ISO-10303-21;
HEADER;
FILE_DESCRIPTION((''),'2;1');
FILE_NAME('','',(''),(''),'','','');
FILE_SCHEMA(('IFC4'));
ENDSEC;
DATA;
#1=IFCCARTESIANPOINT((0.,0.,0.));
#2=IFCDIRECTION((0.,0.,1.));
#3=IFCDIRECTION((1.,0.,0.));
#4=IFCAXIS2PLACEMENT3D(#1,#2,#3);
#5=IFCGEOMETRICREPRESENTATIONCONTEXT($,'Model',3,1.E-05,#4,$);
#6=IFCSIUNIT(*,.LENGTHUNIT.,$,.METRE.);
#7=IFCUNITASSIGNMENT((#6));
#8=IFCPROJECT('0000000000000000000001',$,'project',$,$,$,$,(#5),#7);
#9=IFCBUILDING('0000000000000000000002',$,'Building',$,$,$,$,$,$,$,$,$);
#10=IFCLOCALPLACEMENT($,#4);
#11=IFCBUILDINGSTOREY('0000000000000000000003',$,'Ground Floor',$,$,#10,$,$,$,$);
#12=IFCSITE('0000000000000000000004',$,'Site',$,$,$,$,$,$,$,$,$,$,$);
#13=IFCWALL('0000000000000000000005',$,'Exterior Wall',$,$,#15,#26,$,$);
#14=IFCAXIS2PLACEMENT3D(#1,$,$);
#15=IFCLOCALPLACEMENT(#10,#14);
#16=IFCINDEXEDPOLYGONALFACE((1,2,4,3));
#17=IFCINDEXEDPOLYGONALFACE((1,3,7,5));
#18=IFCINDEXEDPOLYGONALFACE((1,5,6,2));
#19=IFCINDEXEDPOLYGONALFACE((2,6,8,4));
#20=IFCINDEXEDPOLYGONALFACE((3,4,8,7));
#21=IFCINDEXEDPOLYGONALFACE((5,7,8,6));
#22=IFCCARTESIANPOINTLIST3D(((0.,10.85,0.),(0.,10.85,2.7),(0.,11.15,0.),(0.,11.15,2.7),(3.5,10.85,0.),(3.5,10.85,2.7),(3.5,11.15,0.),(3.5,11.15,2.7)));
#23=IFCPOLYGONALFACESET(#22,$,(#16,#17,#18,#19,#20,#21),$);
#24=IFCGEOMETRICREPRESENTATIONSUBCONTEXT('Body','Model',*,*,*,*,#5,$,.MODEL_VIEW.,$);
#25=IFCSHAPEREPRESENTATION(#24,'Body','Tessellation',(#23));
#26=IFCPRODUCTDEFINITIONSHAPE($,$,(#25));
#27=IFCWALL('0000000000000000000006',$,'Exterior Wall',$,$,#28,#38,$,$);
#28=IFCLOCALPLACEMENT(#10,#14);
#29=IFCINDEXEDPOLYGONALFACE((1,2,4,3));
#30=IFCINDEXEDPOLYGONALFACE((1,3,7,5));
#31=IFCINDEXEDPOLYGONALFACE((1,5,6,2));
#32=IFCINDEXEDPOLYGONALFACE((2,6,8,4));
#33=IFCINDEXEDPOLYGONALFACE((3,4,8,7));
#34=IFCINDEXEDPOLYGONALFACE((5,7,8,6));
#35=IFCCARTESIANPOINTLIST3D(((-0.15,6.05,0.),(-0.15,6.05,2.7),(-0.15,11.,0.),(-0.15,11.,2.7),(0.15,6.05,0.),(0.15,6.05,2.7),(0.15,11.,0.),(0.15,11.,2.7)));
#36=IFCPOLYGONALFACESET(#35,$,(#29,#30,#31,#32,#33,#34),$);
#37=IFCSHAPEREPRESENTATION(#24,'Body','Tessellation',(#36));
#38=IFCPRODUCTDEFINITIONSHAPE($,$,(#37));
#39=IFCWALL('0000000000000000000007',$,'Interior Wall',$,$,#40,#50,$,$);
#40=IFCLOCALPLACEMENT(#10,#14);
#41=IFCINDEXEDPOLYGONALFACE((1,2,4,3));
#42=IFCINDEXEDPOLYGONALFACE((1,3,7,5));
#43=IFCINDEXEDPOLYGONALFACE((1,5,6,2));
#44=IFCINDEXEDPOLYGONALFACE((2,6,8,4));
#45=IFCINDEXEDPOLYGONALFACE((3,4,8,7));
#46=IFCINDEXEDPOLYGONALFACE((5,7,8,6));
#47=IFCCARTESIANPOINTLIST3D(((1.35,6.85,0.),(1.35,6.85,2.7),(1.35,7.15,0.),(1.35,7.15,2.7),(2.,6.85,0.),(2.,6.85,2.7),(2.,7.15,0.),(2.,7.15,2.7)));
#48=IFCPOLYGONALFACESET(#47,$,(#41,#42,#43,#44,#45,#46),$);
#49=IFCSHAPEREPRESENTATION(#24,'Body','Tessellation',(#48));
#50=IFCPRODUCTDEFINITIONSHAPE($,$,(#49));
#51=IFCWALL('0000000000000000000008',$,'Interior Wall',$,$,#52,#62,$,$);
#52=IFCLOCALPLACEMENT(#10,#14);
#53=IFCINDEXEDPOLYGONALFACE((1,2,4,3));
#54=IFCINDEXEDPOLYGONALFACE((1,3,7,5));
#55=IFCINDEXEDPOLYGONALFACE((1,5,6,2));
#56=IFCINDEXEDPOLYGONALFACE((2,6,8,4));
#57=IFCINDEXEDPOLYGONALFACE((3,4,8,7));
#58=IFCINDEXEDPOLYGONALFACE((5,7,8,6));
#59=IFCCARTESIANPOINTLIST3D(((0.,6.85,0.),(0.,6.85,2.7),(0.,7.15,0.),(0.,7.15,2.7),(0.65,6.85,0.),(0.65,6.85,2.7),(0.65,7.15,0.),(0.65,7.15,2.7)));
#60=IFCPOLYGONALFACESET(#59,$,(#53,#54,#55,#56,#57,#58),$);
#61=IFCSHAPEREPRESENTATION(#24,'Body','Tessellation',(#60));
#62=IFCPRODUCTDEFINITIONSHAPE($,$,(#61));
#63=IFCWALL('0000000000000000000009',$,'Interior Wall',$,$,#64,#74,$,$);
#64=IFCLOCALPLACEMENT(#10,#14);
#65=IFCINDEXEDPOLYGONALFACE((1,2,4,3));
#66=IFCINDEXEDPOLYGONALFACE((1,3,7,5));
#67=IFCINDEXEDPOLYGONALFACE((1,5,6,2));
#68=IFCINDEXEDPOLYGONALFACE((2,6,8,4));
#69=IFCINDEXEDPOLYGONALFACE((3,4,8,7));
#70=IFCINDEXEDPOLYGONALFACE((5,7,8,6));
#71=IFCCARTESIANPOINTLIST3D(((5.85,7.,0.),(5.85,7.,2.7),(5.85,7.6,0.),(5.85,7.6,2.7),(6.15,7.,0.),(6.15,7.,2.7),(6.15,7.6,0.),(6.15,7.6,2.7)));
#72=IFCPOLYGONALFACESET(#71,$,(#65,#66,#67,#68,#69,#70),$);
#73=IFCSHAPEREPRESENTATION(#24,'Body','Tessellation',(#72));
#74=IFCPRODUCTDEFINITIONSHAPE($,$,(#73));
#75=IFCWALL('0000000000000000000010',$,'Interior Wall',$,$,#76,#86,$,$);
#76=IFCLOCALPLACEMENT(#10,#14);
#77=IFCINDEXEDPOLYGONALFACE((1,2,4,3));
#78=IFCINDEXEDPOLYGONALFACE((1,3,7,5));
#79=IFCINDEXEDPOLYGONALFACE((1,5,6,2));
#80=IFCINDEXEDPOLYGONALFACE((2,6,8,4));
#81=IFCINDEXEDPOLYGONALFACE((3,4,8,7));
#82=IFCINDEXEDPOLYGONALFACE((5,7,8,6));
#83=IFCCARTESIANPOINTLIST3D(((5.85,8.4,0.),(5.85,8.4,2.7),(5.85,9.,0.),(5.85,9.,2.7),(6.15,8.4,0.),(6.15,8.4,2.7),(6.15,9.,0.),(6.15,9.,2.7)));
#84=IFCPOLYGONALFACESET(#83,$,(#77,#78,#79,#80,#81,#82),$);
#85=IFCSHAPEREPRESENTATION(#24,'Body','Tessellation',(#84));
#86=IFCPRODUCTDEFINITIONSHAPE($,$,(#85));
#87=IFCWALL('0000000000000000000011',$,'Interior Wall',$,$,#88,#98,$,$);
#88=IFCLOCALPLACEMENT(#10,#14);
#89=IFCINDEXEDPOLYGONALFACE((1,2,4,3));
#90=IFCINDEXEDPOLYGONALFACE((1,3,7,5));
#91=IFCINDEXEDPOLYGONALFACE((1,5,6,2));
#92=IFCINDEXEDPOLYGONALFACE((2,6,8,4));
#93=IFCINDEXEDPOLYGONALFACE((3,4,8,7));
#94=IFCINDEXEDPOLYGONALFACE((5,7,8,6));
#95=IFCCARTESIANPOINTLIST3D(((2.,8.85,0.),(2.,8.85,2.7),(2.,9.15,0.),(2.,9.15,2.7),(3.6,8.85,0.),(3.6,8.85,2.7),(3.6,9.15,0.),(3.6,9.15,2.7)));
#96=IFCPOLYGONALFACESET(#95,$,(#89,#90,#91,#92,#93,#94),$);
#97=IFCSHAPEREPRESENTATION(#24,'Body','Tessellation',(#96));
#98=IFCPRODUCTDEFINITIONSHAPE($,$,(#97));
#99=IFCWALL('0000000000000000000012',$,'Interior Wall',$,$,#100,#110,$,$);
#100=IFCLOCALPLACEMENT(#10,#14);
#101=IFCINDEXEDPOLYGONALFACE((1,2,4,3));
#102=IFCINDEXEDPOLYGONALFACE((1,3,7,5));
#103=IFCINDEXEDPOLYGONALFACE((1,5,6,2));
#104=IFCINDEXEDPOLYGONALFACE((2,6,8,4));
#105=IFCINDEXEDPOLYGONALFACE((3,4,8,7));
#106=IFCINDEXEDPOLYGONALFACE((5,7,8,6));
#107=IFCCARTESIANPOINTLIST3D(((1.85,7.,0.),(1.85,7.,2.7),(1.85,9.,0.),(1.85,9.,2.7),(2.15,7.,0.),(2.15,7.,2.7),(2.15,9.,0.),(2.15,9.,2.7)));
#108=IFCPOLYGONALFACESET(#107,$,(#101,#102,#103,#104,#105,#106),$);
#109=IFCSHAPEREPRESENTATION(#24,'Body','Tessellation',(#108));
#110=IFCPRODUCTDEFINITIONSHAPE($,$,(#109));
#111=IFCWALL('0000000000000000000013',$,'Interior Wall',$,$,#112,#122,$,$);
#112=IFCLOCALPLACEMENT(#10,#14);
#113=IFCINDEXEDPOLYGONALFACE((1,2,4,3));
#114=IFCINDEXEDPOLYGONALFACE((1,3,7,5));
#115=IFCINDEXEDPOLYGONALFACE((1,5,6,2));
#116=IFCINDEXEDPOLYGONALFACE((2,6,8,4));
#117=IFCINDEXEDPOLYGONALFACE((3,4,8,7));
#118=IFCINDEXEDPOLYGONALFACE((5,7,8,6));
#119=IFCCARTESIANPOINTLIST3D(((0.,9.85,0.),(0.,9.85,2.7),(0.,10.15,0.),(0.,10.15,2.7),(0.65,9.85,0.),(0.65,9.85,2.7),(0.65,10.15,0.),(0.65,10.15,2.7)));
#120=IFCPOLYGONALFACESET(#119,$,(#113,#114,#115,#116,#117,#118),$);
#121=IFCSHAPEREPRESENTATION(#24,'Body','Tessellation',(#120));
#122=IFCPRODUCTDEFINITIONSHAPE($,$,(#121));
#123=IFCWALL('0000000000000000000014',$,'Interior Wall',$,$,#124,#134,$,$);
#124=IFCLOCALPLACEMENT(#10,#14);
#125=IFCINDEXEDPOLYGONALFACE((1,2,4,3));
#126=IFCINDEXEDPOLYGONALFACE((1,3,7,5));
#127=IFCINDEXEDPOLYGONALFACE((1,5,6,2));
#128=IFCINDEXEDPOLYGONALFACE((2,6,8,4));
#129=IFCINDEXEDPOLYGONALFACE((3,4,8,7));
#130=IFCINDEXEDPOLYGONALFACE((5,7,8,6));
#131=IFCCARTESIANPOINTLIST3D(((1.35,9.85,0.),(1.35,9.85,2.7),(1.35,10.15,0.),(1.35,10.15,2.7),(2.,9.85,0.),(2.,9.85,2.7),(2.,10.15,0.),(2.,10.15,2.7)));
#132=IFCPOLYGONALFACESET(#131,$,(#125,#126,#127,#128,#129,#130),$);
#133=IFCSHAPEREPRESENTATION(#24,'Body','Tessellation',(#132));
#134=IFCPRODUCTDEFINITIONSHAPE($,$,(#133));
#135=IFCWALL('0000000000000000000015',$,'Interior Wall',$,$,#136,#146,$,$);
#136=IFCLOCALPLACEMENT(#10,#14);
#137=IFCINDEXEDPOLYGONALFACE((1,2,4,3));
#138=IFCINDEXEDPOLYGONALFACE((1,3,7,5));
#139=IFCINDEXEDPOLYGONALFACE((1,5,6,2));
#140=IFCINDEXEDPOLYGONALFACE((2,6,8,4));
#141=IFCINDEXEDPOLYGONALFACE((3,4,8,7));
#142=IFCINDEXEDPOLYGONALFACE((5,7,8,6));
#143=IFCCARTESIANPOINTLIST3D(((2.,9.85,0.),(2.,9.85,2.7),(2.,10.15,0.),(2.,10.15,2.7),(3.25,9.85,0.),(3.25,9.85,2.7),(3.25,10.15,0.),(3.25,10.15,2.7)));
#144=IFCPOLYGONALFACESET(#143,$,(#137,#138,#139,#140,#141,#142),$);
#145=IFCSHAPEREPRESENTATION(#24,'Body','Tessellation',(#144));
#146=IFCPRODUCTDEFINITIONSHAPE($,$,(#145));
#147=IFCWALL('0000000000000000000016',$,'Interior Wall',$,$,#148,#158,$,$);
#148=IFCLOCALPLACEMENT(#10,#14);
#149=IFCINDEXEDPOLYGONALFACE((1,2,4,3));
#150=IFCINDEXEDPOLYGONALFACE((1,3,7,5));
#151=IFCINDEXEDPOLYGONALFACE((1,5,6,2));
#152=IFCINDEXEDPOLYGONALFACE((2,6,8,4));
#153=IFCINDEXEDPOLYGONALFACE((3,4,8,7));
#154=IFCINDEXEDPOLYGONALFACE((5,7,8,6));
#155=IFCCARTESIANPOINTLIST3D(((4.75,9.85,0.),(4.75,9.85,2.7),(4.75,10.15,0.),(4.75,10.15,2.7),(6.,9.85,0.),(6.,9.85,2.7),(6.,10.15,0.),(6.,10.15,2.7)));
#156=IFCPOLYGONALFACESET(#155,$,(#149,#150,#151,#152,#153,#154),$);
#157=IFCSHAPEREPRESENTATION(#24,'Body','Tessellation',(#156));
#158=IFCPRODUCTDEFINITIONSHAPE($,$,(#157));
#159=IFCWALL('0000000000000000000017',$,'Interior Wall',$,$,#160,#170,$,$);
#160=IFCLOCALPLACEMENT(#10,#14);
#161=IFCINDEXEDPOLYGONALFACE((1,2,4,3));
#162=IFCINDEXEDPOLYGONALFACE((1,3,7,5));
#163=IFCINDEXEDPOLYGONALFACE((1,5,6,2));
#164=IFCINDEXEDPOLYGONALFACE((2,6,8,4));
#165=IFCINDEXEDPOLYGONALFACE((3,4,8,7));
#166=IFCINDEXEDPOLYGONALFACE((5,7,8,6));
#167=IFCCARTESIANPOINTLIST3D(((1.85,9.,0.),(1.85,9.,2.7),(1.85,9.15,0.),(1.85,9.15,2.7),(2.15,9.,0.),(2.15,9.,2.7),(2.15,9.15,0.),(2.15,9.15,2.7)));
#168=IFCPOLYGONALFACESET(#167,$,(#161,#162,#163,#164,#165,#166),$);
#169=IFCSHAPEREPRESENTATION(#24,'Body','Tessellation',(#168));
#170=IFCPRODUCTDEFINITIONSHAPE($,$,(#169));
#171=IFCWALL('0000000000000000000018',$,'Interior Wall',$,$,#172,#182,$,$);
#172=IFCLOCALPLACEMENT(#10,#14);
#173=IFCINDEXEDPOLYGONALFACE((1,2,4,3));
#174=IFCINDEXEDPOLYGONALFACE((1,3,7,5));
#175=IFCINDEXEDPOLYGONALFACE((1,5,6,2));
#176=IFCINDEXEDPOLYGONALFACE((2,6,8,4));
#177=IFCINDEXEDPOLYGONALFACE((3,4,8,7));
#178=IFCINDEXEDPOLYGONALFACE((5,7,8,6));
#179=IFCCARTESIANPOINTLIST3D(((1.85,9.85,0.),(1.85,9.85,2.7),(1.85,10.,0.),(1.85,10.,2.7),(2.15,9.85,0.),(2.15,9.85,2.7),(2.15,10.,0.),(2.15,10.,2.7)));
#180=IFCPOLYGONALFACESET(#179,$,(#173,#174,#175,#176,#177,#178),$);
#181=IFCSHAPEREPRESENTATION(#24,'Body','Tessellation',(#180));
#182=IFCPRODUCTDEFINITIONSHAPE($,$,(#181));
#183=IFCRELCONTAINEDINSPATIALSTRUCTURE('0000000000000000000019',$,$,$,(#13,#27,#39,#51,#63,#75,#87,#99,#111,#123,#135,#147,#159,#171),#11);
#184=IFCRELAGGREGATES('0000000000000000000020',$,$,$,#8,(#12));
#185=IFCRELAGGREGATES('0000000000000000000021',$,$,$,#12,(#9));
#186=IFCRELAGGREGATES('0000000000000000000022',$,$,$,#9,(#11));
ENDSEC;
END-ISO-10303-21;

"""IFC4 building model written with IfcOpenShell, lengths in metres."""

from ifc_helpers import new_model, si_unit, frame, origin_with_axes, place, context, subcontext, project, spatial, indexed_curve, outline, extrude, element, save


model = new_model("IFC4")

# Units and contexts
model_context = context("Model", 3, precision=1e-05, world=origin_with_axes())
body_context = subcontext(model_context, "Body", "Model", "MODEL_VIEW")
ifc_project = project(units=[si_unit("LENGTHUNIT", "METRE")], contexts=[model_context])

# Site, building, storey
site = spatial("IfcSite", under=ifc_project, Name="Site")
building = spatial("IfcBuilding", under=site, Name="Building")
storey_placement = place(None, origin_with_axes())
storey = spatial("IfcBuildingStorey", under=building, at=storey_placement, Name="Ground Floor")

# Walls
wall_1_placement = place(storey_placement, frame((3.5, 11.0, 0.0), z_axis=(0.0, 0.0, 1.0), x_axis=(-1.0, 0.0, 0.0)))
element("IfcWall", 1, at=wall_1_placement, inside=storey, Name="Exterior Wall", context=body_context, shape_type="SweptSolid", body=[
    extrude(outline(indexed_curve([(0.0, 0.0), (0.0, 0.3), (3.5, 0.3), (3.5, 0.0), (0.0, 0.0)], self_intersect=False)), frame((0.0, -0.15, 0.0), z_axis=(0.0, 0.0, 1.0), x_axis=(1.0, 0.0, 0.0)), (0.0, 0.0, 1.0), 2.7),
])
wall_2_placement = place(storey_placement, frame((0.0, 11.0, 0.0), z_axis=(0.0, 0.0, 1.0), x_axis=(0.0, -1.0, 0.0)))
element("IfcWall", 2, at=wall_2_placement, inside=storey, Name="Exterior Wall", context=body_context, shape_type="SweptSolid", body=[
    extrude(outline(indexed_curve([(0.0, 0.0), (0.0, 0.3), (4.95, 0.3), (4.95, 0.0), (0.0, 0.0)], self_intersect=False)), frame((0.0, -0.15, 0.0), z_axis=(0.0, 0.0, 1.0), x_axis=(1.0, 0.0, 0.0)), (0.0, 0.0, 1.0), 2.7),
])
for number, where, z_axis, x_axis, name in (
    (3, (2.0, 7.0, 0.0), (0.0, 0.0, 1.0), (-1.0, 0.0, 0.0), "Interior Wall"),
    (4, (0.65, 7.0, 0.0), (0.0, 0.0, 1.0), (-1.0, 0.0, 0.0), "Interior Wall"),
):
    element("IfcWall", number, at=place(storey_placement, frame(where, z_axis=z_axis, x_axis=x_axis)), inside=storey, Name=name, context=body_context, shape_type="SweptSolid", body=[
        extrude(outline(indexed_curve([(0.0, 0.0), (0.0, 0.3), (0.65, 0.3), (0.65, 0.0), (0.0, 0.0)], self_intersect=False)), frame((0.0, -0.15, 0.0), z_axis=(0.0, 0.0, 1.0), x_axis=(1.0, 0.0, 0.0)), (0.0, 0.0, 1.0), 2.7),
    ])
for number, where, z_axis, x_axis, name in (
    (5, (6.0, 7.0, 0.0), (0.0, 0.0, 1.0), (0.0, 1.0, 0.0), "Interior Wall"),
    (6, (6.0, 8.4, 0.0), (0.0, 0.0, 1.0), (0.0, 1.0, 0.0), "Interior Wall"),
):
    element("IfcWall", number, at=place(storey_placement, frame(where, z_axis=z_axis, x_axis=x_axis)), inside=storey, Name=name, context=body_context, shape_type="SweptSolid", body=[
        extrude(outline(indexed_curve([(0.0, 0.0), (0.0, 0.3), (0.6, 0.3), (0.6, 0.0), (0.0, 0.0)], self_intersect=False)), frame((0.0, -0.15, 0.0), z_axis=(0.0, 0.0, 1.0), x_axis=(1.0, 0.0, 0.0)), (0.0, 0.0, 1.0), 2.7),
    ])
wall_3_placement = place(storey_placement, frame((3.6, 9.0, 0.0), z_axis=(0.0, 0.0, 1.0), x_axis=(-1.0, 0.0, 0.0)))
element("IfcWall", 7, at=wall_3_placement, inside=storey, Name="Interior Wall", context=body_context, shape_type="SweptSolid", body=[
    extrude(outline(indexed_curve([(0.0, 0.0), (0.0, 0.3), (1.6, 0.3), (1.6, 0.0), (0.0, 0.0)], self_intersect=False)), frame((0.0, -0.15, 0.0), z_axis=(0.0, 0.0, 1.0), x_axis=(1.0, 0.0, 0.0)), (0.0, 0.0, 1.0), 2.7),
])
wall_4_placement = place(storey_placement, frame((2.0, 9.0, 0.0), z_axis=(0.0, 0.0, 1.0), x_axis=(0.0, -1.0, 0.0)))
element("IfcWall", 8, at=wall_4_placement, inside=storey, Name="Interior Wall", context=body_context, shape_type="SweptSolid", body=[
    extrude(outline(indexed_curve([(0.0, 0.0), (0.0, 0.3), (2.0, 0.3), (2.0, 0.0), (0.0, 0.0)], self_intersect=False)), frame((0.0, -0.15, 0.0), z_axis=(0.0, 0.0, 1.0), x_axis=(1.0, 0.0, 0.0)), (0.0, 0.0, 1.0), 2.7),
])
wall_5_placement = place(storey_placement, frame((0.0, 10.0, 0.0), z_axis=(0.0, 0.0, 1.0), x_axis=(1.0, 0.0, 0.0)))
element("IfcWall", 9, at=wall_5_placement, inside=storey, Name="Interior Wall", context=body_context, shape_type="SweptSolid", body=[
    extrude(outline(indexed_curve([(0.0, 0.0), (0.0, 0.3), (0.65, 0.3), (0.65, 0.0), (0.0, 0.0)], self_intersect=False)), frame((0.0, -0.15, 0.0), z_axis=(0.0, 0.0, 1.0), x_axis=(1.0, 0.0, 0.0)), (0.0, 0.0, 1.0), 2.7),
])
wall_6_placement = place(storey_placement, frame((1.35, 10.0, 0.0), z_axis=(0.0, 0.0, 1.0), x_axis=(1.0, 0.0, 0.0)))
element("IfcWall", 10, at=wall_6_placement, inside=storey, Name="Interior Wall", context=body_context, shape_type="SweptSolid", body=[
    extrude(outline(indexed_curve([(0.0, 0.0), (0.0, 0.3), (0.65, 0.3), (0.65, 0.0), (0.0, 0.0)], self_intersect=False)), frame((0.0, -0.15, 0.0), z_axis=(0.0, 0.0, 1.0), x_axis=(1.0, 0.0, 0.0)), (0.0, 0.0, 1.0), 2.7),
])
for number, where, z_axis, x_axis, name in (
    (11, (2.0, 10.0, 0.0), (0.0, 0.0, 1.0), (1.0, 0.0, 0.0), "Interior Wall"),
    (12, (4.75, 10.0, 0.0), (0.0, 0.0, 1.0), (1.0, 0.0, 0.0), "Interior Wall"),
):
    element("IfcWall", number, at=place(storey_placement, frame(where, z_axis=z_axis, x_axis=x_axis)), inside=storey, Name=name, context=body_context, shape_type="SweptSolid", body=[
        extrude(outline(indexed_curve([(0.0, 0.0), (0.0, 0.3), (1.25, 0.3), (1.25, 0.0), (0.0, 0.0)], self_intersect=False)), frame((0.0, -0.15, 0.0), z_axis=(0.0, 0.0, 1.0), x_axis=(1.0, 0.0, 0.0)), (0.0, 0.0, 1.0), 2.7),
    ])
for number, where, z_axis, x_axis, name in (
    (13, (2.0, 9.0, 0.0), (0.0, 0.0, 1.0), (0.0, 1.0, 0.0), "Interior Wall"),
    (14, (2.0, 9.85, 0.0), (0.0, 0.0, 1.0), (0.0, 1.0, 0.0), "Interior Wall"),
):
    element("IfcWall", number, at=place(storey_placement, frame(where, z_axis=z_axis, x_axis=x_axis)), inside=storey, Name=name, context=body_context, shape_type="SweptSolid", body=[
        extrude(outline(indexed_curve([(0.0, 0.0), (0.0, 0.3), (0.15, 0.3), (0.15, 0.0), (0.0, 0.0)], self_intersect=False)), frame((0.0, -0.15, 0.0), z_axis=(0.0, 0.0, 1.0), x_axis=(1.0, 0.0, 0.0)), (0.0, 0.0, 1.0), 2.7),
    ])

save(model, "model.ifc")
